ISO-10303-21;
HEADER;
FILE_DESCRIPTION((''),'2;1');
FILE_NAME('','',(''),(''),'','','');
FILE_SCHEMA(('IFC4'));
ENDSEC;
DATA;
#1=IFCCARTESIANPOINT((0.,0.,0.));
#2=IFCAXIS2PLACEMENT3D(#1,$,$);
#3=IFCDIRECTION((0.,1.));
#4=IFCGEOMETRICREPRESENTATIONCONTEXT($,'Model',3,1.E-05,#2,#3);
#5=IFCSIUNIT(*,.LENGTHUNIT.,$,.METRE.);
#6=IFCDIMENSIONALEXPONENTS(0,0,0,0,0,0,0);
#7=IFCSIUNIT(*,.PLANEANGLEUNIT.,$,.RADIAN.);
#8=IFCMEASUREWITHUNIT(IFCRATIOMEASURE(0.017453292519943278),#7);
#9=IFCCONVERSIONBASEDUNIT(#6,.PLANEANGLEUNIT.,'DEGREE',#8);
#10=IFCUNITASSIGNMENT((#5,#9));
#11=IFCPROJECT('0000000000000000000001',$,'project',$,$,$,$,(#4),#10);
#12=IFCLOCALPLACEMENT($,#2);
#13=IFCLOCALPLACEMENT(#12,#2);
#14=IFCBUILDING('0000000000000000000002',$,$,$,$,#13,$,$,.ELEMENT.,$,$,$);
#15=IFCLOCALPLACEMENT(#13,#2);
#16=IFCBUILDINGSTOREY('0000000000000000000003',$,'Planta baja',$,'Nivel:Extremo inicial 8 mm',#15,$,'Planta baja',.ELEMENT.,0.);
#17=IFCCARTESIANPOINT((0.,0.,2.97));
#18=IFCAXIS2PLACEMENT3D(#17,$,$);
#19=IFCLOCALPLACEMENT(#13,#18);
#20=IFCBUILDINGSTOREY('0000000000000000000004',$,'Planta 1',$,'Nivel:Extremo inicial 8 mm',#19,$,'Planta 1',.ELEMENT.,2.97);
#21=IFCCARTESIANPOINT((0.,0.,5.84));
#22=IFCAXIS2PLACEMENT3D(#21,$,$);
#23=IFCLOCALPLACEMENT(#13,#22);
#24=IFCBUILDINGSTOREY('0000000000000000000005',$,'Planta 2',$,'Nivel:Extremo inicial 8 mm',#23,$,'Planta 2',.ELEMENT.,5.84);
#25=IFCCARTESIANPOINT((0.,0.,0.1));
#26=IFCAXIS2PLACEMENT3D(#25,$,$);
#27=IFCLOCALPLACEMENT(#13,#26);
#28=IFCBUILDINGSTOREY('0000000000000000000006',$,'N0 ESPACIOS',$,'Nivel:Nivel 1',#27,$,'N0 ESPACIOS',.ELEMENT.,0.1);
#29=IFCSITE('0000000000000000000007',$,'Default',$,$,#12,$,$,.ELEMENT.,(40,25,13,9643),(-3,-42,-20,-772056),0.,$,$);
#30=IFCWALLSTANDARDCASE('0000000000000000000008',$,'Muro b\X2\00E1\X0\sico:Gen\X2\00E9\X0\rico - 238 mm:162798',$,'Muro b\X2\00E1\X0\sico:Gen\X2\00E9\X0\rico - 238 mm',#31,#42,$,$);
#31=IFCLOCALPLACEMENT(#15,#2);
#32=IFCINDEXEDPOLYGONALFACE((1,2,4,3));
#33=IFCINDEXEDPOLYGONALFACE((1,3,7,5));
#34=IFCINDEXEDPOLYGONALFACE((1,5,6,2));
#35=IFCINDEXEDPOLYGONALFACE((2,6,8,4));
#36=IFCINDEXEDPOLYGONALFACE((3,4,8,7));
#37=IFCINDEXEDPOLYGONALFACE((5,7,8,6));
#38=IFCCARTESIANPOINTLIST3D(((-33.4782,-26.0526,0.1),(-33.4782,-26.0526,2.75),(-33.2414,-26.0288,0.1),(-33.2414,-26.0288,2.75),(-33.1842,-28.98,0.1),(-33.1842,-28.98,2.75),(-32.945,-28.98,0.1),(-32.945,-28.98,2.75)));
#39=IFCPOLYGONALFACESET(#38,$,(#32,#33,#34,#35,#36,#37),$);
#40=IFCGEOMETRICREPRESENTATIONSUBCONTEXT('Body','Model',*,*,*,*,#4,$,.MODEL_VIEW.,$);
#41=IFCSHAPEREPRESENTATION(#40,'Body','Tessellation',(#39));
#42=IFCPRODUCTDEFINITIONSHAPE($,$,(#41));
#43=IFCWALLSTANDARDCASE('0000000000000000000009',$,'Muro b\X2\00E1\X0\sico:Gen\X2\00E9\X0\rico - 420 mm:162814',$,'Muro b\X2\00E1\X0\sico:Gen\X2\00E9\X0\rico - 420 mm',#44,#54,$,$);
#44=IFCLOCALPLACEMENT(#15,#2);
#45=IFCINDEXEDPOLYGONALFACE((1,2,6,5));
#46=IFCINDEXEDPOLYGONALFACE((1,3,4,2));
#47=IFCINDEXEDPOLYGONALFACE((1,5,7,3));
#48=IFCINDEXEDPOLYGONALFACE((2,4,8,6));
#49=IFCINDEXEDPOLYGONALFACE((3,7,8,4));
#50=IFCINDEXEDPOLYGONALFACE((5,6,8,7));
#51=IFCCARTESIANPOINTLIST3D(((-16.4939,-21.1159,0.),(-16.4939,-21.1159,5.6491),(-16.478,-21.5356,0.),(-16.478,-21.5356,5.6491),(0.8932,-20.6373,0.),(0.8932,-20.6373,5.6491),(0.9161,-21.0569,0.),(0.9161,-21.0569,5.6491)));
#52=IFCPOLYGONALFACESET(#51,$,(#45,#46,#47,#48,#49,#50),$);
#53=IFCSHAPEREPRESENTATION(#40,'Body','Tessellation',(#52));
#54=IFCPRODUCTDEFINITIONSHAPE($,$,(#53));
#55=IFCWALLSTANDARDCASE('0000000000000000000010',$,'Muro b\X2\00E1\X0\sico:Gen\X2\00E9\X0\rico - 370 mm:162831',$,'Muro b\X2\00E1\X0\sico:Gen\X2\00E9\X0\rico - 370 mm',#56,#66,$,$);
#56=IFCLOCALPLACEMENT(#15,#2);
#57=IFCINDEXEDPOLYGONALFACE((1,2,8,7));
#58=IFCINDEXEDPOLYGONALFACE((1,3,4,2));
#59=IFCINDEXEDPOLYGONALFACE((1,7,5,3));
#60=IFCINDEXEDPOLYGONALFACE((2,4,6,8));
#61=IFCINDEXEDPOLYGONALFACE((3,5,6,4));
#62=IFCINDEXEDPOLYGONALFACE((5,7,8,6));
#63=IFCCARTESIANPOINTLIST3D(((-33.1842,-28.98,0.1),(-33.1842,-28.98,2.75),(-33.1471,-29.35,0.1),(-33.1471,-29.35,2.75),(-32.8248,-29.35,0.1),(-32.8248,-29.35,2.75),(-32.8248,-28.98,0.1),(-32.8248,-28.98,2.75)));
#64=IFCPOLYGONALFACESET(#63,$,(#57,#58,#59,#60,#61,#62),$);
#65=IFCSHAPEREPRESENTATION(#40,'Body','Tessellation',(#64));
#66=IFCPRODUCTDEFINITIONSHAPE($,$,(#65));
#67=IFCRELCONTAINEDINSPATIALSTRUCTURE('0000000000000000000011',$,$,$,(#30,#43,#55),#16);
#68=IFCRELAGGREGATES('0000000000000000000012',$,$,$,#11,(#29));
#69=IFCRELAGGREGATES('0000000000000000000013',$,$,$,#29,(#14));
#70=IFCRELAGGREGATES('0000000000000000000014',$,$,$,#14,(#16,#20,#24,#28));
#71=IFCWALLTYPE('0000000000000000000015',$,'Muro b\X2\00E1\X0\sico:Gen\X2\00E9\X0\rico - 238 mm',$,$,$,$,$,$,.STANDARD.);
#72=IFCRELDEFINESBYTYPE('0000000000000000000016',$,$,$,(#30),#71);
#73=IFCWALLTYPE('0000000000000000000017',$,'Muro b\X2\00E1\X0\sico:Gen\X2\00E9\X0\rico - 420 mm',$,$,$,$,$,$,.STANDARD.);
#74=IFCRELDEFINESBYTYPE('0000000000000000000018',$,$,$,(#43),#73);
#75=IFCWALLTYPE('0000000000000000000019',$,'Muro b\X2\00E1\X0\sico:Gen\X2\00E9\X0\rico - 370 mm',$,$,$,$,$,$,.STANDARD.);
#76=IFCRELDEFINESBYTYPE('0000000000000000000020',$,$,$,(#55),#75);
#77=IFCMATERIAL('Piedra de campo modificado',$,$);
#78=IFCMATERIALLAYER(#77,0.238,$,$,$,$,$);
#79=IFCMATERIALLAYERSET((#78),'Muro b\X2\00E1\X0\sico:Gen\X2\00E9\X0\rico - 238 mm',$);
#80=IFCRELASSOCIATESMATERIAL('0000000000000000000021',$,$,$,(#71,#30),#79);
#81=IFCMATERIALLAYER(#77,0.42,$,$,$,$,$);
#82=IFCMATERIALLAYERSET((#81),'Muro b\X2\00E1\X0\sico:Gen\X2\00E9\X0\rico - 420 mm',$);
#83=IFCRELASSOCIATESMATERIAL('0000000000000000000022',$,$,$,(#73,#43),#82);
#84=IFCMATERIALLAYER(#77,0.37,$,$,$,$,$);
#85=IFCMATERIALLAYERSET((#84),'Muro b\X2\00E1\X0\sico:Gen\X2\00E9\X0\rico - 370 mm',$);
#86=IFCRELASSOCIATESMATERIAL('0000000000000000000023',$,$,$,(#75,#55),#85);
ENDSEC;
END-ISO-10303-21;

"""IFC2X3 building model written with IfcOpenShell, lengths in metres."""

from ifc_helpers import new_model, entity, si_unit, converted_unit, direction, frame, origin, place, context, subcontext, project, spatial, polyline, outline, extrude, clip, bounded_halfspace, material, layer, layer_set, layer_usage, type_object, element, save


model = new_model("IFC2X3")

# Units and contexts
model_context = context("Model", 3, precision=1e-05, world=origin(), true_north=direction((0.0, 1.0)))
body_context = subcontext(model_context, "Body", "Model", "MODEL_VIEW")
ifc_project = project(units=[si_unit("LENGTHUNIT", "METRE"), converted_unit("PLANEANGLEUNIT", "DEGREE", entity("IfcRatioMeasure", 0.017453292519943278), si_unit("PLANEANGLEUNIT", "RADIAN"), dimensions=[0, 0, 0, 0, 0, 0, 0])], contexts=[model_context])

# Site, building, storey
site_placement = place(None, origin())
site = spatial("IfcSite", under=ifc_project, at=site_placement, Name="Default", CompositionType="ELEMENT", RefLatitude=(40, 25, 13, 9643), RefLongitude=(-3, -42, -20, -772056), RefElevation=0.0)
building_placement = place(site_placement, origin())
building = spatial("IfcBuilding", under=site, at=building_placement, CompositionType="ELEMENT")
storey_1_placement = place(building_placement, origin())
storey_1 = spatial("IfcBuildingStorey", under=building, at=storey_1_placement, Name="Planta baja", ObjectType="Nivel:Extremo inicial 8 mm", LongName="Planta baja", CompositionType="ELEMENT", Elevation=0.0)

# Shared definitions
ifc_material_1 = material(Name="Piedra de campo modificado")

# Shared definitions
storey_2_placement = place(building_placement, frame((0.0, 0.0, 2.97)))
storey_2 = spatial("IfcBuildingStorey", under=building, at=storey_2_placement, Name="Planta 1", ObjectType="Nivel:Extremo inicial 8 mm", LongName="Planta 1", CompositionType="ELEMENT", Elevation=2.97)

# Shared definitions
storey_3_placement = place(building_placement, frame((0.0, 0.0, 5.84)))
storey_3 = spatial("IfcBuildingStorey", under=building, at=storey_3_placement, Name="Planta 2", ObjectType="Nivel:Extremo inicial 8 mm", LongName="Planta 2", CompositionType="ELEMENT", Elevation=5.84)

# Wall
ifc_layer_1 = layer(ifc_material_1, 0.238)
ifc_layer_set_1 = layer_set([ifc_layer_1], Name="Muro básico:Genérico - 238 mm")
ifc_layer_usage_1 = layer_usage(ifc_layer_set_1, "AXIS2", "NEGATIVE", 0.119)
wall_type_1 = type_object("IfcWallType", Name="Muro básico:Genérico - 238 mm", PredefinedType="STANDARD", material=ifc_layer_set_1)
wall_1_placement = place(storey_1_placement, frame((-33.3598, -26.0407, 0.1), z_axis=(0.0, 0.0, 1.0), x_axis=(0.09992, -0.994996, 0.0)))
element("IfcWallStandardCase", 1, at=wall_1_placement, inside=storey_1, type_object=wall_type_1, material=ifc_layer_usage_1, Name="Muro básico:Genérico - 238 mm:162798", ObjectType="Muro básico:Genérico - 238 mm", context=body_context, shape_type="Clipping", body=[
    clip(extrude(outline(polyline([(2.9421, -0.119), (2.966, 0.119), (0.0, 0.119), (0.0, -0.119), (2.9421, -0.119)])), origin(), (0.0, 0.0, 1.0), 2.65), bounded_halfspace(frame((0.0216, -0.119, 2.65), z_axis=(0.0, 0.0, -1.0), x_axis=(-1.0, 0.0, 0.0)), True, frame((0.0216, -0.119, 2.65)), polyline([(0.0, 0.0), (2.9205, 0.0), (2.9444, 0.238), (0.0283, 0.238), (0.0, 0.0)]))),
])

# Shared definitions
storey_4_placement = place(building_placement, frame((0.0, 0.0, 0.1)))
storey_4 = spatial("IfcBuildingStorey", under=building, at=storey_4_placement, Name="N0 ESPACIOS", ObjectType="Nivel:Nivel 1", LongName="N0 ESPACIOS", CompositionType="ELEMENT", Elevation=0.1)

# Walls
ifc_layer_2 = layer(ifc_material_1, 0.42)
ifc_layer_set_2 = layer_set([ifc_layer_2], Name="Muro básico:Genérico - 420 mm")
ifc_layer_usage_2 = layer_usage(ifc_layer_set_2, "AXIS2", "NEGATIVE", 0.21)
wall_type_2 = type_object("IfcWallType", Name="Muro básico:Genérico - 420 mm", PredefinedType="STANDARD", material=ifc_layer_set_2)
wall_2_placement = place(storey_1_placement, frame((-16.4881, -21.3258, 0.0), z_axis=(0.0, 0.0, 1.0), x_axis=(0.999621, 0.027514, 0.0)))
element("IfcWallStandardCase", 2, at=wall_2_placement, inside=storey_1, type_object=wall_type_2, material=ifc_layer_usage_2, Name="Muro básico:Genérico - 420 mm:162814", ObjectType="Muro básico:Genérico - 420 mm", context=body_context, shape_type="SweptSolid", body=[
    extrude(outline(polyline([(17.405, -0.21), (17.3937, 0.21), (0.0, 0.21), (0.0043, -0.21), (17.405, -0.21)])), origin(), (0.0, 0.0, 1.0), 5.6491),
])
ifc_layer_3 = layer(ifc_material_1, 0.37)
ifc_layer_set_3 = layer_set([ifc_layer_3], Name="Muro básico:Genérico - 370 mm")
ifc_layer_usage_3 = layer_usage(ifc_layer_set_3, "AXIS2", "NEGATIVE", 0.185)
wall_type_3 = type_object("IfcWallType", Name="Muro básico:Genérico - 370 mm", PredefinedType="STANDARD", material=ifc_layer_set_3)
wall_3_placement = place(storey_1_placement, frame((-33.1842, -29.165, 0.1)))
element("IfcWallStandardCase", 3, at=wall_3_placement, inside=storey_1, type_object=wall_type_3, material=ifc_layer_usage_3, Name="Muro básico:Genérico - 370 mm:162831", ObjectType="Muro básico:Genérico - 370 mm", context=body_context, shape_type="Clipping", body=[
    clip(extrude(outline(polyline([(0.3595, -0.185), (0.3595, 0.135), (0.3595, 0.185), (0.2392, 0.185), (0.0, 0.185), (0.0372, -0.185), (0.3595, -0.185)])), origin(), (0.0, 0.0, 1.0), 2.65), bounded_halfspace(frame((0.0372, -0.185, 2.65), z_axis=(0.0, 0.0, -1.0), x_axis=(-0.09992, 0.994996, 0.0)), True, frame((0.0372, -0.185, 2.65)), polyline([(0.0, 0.0), (0.3223, 0.0), (0.3223, 0.32), (0.3223, 0.37), (0.202, 0.37), (-0.0372, 0.37), (0.0, 0.0)]))),
])

save(model, "model.ifc")
